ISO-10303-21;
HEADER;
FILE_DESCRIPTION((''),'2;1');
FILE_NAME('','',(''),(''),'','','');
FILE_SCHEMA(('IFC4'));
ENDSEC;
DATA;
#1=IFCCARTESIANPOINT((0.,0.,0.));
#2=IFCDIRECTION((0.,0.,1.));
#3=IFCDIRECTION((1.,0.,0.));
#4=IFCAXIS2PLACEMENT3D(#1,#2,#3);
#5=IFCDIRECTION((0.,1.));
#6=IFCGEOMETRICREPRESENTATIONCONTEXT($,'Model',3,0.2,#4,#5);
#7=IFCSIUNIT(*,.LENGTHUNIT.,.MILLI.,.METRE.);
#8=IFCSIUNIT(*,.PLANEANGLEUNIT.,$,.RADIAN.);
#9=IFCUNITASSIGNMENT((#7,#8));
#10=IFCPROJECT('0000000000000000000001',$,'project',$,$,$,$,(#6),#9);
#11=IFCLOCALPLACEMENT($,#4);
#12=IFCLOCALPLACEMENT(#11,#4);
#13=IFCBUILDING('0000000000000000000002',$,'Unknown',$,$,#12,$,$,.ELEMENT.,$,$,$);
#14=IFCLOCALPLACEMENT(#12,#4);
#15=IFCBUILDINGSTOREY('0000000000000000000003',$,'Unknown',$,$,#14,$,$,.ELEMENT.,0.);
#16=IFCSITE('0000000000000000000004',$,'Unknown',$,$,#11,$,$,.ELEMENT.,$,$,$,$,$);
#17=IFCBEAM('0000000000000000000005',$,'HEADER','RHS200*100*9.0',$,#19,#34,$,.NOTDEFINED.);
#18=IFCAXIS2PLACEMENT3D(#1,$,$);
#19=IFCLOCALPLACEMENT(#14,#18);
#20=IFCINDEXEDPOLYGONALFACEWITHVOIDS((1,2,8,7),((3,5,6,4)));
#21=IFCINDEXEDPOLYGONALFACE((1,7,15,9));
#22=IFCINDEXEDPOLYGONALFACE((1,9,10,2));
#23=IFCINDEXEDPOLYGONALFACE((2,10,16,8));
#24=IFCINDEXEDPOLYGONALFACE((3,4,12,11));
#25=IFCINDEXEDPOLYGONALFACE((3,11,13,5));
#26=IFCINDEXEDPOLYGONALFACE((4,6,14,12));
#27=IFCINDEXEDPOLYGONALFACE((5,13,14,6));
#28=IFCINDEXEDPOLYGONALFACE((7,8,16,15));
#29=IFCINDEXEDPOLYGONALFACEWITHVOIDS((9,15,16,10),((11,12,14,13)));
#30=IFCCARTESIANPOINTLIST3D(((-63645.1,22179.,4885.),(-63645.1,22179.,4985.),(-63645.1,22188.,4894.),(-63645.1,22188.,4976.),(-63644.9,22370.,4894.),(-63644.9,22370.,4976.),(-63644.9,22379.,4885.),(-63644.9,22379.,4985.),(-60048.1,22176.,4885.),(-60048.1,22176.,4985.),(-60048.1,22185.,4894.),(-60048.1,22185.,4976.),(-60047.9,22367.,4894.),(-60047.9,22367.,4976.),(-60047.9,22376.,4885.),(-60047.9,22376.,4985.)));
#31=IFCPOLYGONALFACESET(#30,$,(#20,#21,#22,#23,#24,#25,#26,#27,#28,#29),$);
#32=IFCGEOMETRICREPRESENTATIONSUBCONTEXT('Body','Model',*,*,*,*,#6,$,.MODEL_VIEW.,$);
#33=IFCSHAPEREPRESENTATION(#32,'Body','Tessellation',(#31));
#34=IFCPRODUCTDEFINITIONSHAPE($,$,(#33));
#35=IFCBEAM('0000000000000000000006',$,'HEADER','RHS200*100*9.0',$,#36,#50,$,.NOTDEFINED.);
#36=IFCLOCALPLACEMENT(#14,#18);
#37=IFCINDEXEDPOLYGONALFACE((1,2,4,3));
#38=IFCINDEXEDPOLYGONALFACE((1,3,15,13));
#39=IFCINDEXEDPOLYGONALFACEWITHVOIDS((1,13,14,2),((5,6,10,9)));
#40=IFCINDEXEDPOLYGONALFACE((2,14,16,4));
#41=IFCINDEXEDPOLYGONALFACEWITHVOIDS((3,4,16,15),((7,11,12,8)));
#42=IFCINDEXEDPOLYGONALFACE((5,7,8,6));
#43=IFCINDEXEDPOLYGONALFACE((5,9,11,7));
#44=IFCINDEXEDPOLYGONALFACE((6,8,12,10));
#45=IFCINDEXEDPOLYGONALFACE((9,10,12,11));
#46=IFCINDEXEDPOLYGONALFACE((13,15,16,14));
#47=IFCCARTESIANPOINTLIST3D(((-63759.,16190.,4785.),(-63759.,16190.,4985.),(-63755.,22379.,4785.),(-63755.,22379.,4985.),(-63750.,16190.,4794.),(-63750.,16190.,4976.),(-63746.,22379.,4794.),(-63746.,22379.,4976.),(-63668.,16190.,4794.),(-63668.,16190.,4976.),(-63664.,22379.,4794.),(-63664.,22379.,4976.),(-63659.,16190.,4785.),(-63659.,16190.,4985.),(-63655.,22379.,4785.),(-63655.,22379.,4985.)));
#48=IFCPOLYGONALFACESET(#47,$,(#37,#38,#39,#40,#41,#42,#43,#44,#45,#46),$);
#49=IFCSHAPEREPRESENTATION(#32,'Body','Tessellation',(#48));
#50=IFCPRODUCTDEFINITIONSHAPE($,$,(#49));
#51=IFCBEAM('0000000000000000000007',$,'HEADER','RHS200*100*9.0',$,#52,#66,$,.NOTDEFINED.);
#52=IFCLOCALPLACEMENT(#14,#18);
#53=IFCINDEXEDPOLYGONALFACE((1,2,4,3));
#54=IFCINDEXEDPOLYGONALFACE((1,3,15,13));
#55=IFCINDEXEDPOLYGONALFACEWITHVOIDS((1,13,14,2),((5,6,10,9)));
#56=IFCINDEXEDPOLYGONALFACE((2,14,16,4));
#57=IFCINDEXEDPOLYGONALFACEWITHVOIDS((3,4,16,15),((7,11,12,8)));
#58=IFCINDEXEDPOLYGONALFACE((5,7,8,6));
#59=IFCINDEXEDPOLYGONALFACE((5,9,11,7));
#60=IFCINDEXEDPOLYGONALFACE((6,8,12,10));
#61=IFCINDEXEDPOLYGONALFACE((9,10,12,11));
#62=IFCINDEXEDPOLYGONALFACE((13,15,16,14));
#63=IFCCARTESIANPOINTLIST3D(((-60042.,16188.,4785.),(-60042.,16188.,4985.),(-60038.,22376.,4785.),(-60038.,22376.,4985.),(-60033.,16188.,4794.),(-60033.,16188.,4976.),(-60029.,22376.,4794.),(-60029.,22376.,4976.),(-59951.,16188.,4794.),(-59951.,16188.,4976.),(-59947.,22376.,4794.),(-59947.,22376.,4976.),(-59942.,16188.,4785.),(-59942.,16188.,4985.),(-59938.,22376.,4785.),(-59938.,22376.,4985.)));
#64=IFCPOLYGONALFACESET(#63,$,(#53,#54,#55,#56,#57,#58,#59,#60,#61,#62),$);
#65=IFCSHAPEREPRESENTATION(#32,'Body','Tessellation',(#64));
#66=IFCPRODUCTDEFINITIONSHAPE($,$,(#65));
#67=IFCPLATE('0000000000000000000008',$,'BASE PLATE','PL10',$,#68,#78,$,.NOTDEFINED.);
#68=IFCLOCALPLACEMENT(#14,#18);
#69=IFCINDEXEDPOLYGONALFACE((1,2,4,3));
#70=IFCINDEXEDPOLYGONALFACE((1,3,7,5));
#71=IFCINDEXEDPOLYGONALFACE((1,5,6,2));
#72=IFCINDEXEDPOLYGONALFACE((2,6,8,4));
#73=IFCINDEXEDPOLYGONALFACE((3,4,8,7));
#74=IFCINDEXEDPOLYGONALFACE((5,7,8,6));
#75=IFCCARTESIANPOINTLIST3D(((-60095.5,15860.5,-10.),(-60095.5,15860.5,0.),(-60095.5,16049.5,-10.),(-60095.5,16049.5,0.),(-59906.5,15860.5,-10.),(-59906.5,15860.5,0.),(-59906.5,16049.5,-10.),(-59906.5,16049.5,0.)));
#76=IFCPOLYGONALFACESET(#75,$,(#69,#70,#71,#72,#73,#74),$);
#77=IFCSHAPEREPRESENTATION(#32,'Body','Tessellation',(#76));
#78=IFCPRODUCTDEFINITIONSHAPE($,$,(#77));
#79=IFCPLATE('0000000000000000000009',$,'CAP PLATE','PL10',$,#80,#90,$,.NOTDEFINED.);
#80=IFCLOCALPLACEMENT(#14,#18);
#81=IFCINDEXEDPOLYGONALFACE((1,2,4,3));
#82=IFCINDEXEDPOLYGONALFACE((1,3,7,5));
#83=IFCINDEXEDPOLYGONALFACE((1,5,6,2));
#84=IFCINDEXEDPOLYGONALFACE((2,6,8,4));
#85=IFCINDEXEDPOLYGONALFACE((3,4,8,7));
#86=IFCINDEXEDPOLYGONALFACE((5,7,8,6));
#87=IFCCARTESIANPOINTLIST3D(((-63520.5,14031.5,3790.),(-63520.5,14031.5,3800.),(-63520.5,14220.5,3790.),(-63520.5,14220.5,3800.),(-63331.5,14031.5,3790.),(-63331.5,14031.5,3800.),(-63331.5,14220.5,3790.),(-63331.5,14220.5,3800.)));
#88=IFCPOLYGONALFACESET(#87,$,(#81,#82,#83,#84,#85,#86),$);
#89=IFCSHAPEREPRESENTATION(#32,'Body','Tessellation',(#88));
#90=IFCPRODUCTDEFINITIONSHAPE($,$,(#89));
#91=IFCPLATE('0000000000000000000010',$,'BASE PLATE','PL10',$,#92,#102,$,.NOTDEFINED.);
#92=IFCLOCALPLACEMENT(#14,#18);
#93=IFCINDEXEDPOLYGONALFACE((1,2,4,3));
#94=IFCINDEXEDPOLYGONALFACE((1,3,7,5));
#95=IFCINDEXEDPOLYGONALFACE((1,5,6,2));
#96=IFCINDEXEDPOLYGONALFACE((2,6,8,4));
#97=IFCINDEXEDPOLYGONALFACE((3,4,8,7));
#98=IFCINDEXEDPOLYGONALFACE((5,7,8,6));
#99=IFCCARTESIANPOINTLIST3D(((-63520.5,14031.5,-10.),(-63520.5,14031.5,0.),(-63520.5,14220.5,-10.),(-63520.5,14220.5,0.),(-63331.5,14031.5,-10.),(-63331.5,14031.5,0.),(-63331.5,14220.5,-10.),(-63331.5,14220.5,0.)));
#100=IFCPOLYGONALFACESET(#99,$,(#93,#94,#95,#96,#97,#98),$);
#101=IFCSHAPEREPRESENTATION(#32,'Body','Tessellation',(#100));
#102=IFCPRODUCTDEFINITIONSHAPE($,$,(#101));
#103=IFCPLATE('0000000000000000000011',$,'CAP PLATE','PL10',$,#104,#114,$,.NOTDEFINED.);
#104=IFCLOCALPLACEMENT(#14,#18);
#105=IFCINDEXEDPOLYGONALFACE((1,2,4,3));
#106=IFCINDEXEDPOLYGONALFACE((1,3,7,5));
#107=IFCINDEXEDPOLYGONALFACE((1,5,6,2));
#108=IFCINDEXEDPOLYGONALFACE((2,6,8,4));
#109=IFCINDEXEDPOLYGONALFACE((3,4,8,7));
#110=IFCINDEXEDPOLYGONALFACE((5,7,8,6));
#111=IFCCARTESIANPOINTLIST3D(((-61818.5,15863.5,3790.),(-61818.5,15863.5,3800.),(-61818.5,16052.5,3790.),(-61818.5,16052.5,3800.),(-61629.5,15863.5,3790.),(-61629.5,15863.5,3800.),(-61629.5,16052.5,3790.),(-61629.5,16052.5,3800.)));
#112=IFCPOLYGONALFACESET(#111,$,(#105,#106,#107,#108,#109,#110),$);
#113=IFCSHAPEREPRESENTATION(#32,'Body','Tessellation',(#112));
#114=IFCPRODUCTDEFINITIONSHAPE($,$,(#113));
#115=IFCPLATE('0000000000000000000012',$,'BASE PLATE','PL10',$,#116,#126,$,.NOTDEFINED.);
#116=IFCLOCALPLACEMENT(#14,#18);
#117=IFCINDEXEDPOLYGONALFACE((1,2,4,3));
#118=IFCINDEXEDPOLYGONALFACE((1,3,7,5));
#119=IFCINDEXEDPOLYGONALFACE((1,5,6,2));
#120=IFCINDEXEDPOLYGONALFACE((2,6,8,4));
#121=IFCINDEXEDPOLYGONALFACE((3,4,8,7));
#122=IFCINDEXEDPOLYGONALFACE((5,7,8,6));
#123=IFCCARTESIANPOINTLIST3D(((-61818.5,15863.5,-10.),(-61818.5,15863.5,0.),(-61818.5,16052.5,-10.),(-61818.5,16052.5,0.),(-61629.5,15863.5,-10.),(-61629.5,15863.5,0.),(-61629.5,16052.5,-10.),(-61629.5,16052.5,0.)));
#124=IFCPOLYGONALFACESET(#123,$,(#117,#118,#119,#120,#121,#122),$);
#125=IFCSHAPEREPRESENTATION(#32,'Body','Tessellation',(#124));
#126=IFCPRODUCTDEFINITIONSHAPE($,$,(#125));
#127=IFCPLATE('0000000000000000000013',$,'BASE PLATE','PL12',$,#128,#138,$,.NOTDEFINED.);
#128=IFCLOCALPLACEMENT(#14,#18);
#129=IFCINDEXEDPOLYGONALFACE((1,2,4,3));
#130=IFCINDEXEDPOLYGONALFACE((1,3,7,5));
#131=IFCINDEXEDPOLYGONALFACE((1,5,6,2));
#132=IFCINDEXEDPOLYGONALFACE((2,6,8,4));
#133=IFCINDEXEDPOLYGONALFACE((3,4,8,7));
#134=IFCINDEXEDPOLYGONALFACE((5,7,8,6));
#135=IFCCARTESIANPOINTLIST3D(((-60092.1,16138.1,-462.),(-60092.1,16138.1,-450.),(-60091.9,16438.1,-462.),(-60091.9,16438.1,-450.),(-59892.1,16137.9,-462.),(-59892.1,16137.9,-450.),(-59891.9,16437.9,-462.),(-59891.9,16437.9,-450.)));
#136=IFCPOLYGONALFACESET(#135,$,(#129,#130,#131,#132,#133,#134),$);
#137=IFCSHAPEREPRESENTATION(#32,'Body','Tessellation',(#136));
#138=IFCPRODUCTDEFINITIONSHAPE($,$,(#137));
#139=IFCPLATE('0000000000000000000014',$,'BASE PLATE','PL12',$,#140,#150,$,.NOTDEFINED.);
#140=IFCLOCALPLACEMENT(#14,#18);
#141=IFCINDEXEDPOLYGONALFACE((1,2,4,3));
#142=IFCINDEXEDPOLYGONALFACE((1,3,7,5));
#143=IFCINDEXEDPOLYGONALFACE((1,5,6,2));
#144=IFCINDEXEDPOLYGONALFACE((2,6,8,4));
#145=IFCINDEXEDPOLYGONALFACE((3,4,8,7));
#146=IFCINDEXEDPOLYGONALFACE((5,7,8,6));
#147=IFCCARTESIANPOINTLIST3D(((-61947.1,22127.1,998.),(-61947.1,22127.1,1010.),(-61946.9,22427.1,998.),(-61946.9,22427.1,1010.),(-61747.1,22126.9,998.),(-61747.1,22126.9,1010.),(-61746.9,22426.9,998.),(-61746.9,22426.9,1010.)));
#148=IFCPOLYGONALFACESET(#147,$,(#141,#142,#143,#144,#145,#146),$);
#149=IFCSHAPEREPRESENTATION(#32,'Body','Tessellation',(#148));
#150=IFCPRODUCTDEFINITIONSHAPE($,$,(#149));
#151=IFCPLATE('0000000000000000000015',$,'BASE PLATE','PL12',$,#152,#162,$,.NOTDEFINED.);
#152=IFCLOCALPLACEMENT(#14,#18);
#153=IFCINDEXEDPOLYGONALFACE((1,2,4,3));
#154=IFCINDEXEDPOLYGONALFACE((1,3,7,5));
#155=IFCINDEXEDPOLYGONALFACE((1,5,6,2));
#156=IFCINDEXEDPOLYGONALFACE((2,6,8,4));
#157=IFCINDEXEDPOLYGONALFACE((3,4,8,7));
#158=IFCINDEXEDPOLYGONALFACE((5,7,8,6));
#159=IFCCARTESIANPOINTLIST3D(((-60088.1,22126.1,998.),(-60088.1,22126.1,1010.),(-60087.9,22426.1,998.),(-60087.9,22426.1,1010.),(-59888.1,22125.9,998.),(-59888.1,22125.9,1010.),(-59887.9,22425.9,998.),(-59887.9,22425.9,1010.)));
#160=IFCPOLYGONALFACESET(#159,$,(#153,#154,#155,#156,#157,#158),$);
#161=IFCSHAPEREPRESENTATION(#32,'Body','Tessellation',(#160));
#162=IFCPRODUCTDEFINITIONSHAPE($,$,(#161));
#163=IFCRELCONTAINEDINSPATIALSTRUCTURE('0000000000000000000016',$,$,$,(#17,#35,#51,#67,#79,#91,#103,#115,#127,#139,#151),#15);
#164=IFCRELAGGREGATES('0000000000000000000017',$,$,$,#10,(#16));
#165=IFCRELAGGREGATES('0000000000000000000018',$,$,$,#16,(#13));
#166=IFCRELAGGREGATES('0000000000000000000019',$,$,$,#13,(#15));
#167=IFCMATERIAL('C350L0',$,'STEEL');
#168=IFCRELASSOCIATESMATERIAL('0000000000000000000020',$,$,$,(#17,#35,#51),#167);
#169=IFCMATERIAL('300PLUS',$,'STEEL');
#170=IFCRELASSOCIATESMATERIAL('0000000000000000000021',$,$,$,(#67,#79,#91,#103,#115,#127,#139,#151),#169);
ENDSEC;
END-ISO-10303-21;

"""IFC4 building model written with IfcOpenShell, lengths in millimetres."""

from ifc_helpers import new_model, si_unit, direction, frame, origin_with_axes, place, context, subcontext, project, spatial, line, indexed_curve, outline, extrude, material, element, save


model = new_model("IFC4")

# Units and contexts
model_context = context("Model", 3, precision=0.2, world=origin_with_axes(), true_north=direction((0.0, 1.0)))
body_context = subcontext(model_context, "Body", "Model", "MODEL_VIEW")
ifc_project = project(units=[si_unit("LENGTHUNIT", "METRE", prefix="MILLI"), si_unit("PLANEANGLEUNIT", "RADIAN")], contexts=[model_context])

# Site, building, storey
site_placement = place(None, origin_with_axes())
site = spatial("IfcSite", under=ifc_project, at=site_placement, Name="Unknown", CompositionType="ELEMENT")
building_placement = place(site_placement, origin_with_axes())
building = spatial("IfcBuilding", under=site, at=building_placement, Name="Unknown", CompositionType="ELEMENT")
storey_placement = place(building_placement, origin_with_axes())
storey = spatial("IfcBuildingStorey", under=building, at=storey_placement, Name="Unknown", CompositionType="ELEMENT", Elevation=0.0)

# Shared definitions
ifc_material_1 = material(Name="C350L0", Category="STEEL")

# Beams
beam_1_placement = place(storey_placement, frame((-60048.0, 22276.0, 4935.0), z_axis=(0.0, 0.0, 1.0), x_axis=(-1.0, 0.000834, 0.0)))
element("IfcBeam", 1, at=beam_1_placement, inside=storey, material=ifc_material_1, Name="HEADER", Description="RHS200*100*9.0", PredefinedType="NOTDEFINED", context=body_context, shape_type="SolidModel", body=[
    extrude(outline(indexed_curve([(-50.0, -100.0), (50.0, -100.0), (50.0, 100.0), (-50.0, 100.0)], segments=[line(1, 2, 3, 4, 1)]), holes=[indexed_curve([(-41.0, -91.0), (-41.0, 91.0), (41.0, 91.0), (41.0, -91.0)], segments=[line(1, 2, 3, 4, 1)])]), frame((0.0, 0.0, 0.0), z_axis=(-1.0, 0.0, 0.0), x_axis=(0.0, 0.0, 1.0)), (0.0, 0.0, -1.0), 3597.0),
])
beam_2_placement = place(storey_placement, frame((-63709.0, 16190.0, 4885.0), z_axis=(1.0, -0.000646, 0.0), x_axis=(0.000646, 1.0, 0.0)))
element("IfcBeam", 2, at=beam_2_placement, inside=storey, material=ifc_material_1, Name="HEADER", Description="RHS200*100*9.0", PredefinedType="NOTDEFINED", context=body_context, shape_type="SolidModel", body=[
    extrude(outline(indexed_curve([(-50.0, -100.0), (50.0, -100.0), (50.0, 100.0), (-50.0, 100.0)], segments=[line(1, 2, 3, 4, 1)]), holes=[indexed_curve([(-41.0, -91.0), (-41.0, 91.0), (41.0, 91.0), (41.0, -91.0)], segments=[line(1, 2, 3, 4, 1)])]), frame((0.0, 0.0, 0.0), z_axis=(-1.0, 0.0, 0.0), x_axis=(0.0, 0.0, 1.0)), (0.0, 0.0, -1.0), 6189.0),
])
beam_3_placement = place(storey_placement, frame((-59992.0, 16188.0, 4885.0), z_axis=(1.0, -0.000646, 0.0), x_axis=(0.000646, 1.0, 0.0)))
element("IfcBeam", 3, at=beam_3_placement, inside=storey, material=ifc_material_1, Name="HEADER", Description="RHS200*100*9.0", PredefinedType="NOTDEFINED", context=body_context, shape_type="SolidModel", body=[
    extrude(outline(indexed_curve([(-50.0, -100.0), (50.0, -100.0), (50.0, 100.0), (-50.0, 100.0)], segments=[line(1, 2, 3, 4, 1)]), holes=[indexed_curve([(-41.0, -91.0), (-41.0, 91.0), (41.0, 91.0), (41.0, -91.0)], segments=[line(1, 2, 3, 4, 1)])]), frame((0.0, 0.0, 0.0), z_axis=(-1.0, 0.0, 0.0), x_axis=(0.0, 0.0, 1.0)), (0.0, 0.0, -1.0), 6188.0),
])

# Plates
ifc_material_2 = material(Name="300PLUS", Category="STEEL")
for number, where, z_axis, x_axis, name in (
    (4, (-60095.5, 15860.5, -5.0), (0.0, 0.0, 1.0), (1.0, 0.0, 0.0), "BASE PLATE"),
    (5, (-63520.5, 14031.5, 3795.0), (0.0, 0.0, 1.0), (1.0, 0.0, 0.0), "CAP PLATE"),
    (6, (-63520.5, 14031.5, -5.0), (0.0, 0.0, 1.0), (1.0, 0.0, 0.0), "BASE PLATE"),
    (7, (-61818.5, 15863.5, 3795.0), (0.0, 0.0, 1.0), (1.0, 0.0, 0.0), "CAP PLATE"),
    (8, (-61818.5, 15863.5, -5.0), (0.0, 0.0, 1.0), (1.0, 0.0, 0.0), "BASE PLATE"),
):
    element("IfcPlate", number, at=place(storey_placement, frame(where, z_axis=z_axis, x_axis=x_axis)), inside=storey, material=ifc_material_2, Name=name, Description="PL10", PredefinedType="NOTDEFINED", context=body_context, shape_type="SolidModel", body=[
        extrude(outline(indexed_curve([(0.0, 0.0), (189.0, 0.0), (189.0, 189.0), (0.0, 189.0)], segments=[line(1, 2, 3, 4, 1)])), frame((0.0, 0.0, 5.0), z_axis=(0.0, 0.0, 1.0), x_axis=(1.0, 0.0, 0.0)), (0.0, 0.0, -1.0), 10.0),
    ])
for number, where, z_axis, x_axis, name in (
    (9, (-60091.9, 16438.1, -456.0), (0.0, 0.0, 1.0), (-0.000667, -1.0, 0.0), "BASE PLATE"),
    (10, (-61946.9, 22427.1, 1004.0), (0.0, 0.0, 1.0), (-0.000667, -1.0, 0.0), "BASE PLATE"),
    (11, (-60087.9, 22426.1, 1004.0), (0.0, 0.0, 1.0), (-0.000667, -1.0, 0.0), "BASE PLATE"),
):
    element("IfcPlate", number, at=place(storey_placement, frame(where, z_axis=z_axis, x_axis=x_axis)), inside=storey, material=ifc_material_2, Name=name, Description="PL12", PredefinedType="NOTDEFINED", context=body_context, shape_type="SolidModel", body=[
        extrude(outline(indexed_curve([(0.0, 0.0), (300.0, 0.0), (300.1, 200.0), (0.1, 200.0)], segments=[line(1, 2, 3, 4, 1)])), frame((0.0, 0.0, 6.0), z_axis=(0.0, 0.0, 1.0), x_axis=(1.0, 0.0, 0.0)), (0.0, 0.0, -1.0), 12.0),
    ])

save(model, "model.ifc")
